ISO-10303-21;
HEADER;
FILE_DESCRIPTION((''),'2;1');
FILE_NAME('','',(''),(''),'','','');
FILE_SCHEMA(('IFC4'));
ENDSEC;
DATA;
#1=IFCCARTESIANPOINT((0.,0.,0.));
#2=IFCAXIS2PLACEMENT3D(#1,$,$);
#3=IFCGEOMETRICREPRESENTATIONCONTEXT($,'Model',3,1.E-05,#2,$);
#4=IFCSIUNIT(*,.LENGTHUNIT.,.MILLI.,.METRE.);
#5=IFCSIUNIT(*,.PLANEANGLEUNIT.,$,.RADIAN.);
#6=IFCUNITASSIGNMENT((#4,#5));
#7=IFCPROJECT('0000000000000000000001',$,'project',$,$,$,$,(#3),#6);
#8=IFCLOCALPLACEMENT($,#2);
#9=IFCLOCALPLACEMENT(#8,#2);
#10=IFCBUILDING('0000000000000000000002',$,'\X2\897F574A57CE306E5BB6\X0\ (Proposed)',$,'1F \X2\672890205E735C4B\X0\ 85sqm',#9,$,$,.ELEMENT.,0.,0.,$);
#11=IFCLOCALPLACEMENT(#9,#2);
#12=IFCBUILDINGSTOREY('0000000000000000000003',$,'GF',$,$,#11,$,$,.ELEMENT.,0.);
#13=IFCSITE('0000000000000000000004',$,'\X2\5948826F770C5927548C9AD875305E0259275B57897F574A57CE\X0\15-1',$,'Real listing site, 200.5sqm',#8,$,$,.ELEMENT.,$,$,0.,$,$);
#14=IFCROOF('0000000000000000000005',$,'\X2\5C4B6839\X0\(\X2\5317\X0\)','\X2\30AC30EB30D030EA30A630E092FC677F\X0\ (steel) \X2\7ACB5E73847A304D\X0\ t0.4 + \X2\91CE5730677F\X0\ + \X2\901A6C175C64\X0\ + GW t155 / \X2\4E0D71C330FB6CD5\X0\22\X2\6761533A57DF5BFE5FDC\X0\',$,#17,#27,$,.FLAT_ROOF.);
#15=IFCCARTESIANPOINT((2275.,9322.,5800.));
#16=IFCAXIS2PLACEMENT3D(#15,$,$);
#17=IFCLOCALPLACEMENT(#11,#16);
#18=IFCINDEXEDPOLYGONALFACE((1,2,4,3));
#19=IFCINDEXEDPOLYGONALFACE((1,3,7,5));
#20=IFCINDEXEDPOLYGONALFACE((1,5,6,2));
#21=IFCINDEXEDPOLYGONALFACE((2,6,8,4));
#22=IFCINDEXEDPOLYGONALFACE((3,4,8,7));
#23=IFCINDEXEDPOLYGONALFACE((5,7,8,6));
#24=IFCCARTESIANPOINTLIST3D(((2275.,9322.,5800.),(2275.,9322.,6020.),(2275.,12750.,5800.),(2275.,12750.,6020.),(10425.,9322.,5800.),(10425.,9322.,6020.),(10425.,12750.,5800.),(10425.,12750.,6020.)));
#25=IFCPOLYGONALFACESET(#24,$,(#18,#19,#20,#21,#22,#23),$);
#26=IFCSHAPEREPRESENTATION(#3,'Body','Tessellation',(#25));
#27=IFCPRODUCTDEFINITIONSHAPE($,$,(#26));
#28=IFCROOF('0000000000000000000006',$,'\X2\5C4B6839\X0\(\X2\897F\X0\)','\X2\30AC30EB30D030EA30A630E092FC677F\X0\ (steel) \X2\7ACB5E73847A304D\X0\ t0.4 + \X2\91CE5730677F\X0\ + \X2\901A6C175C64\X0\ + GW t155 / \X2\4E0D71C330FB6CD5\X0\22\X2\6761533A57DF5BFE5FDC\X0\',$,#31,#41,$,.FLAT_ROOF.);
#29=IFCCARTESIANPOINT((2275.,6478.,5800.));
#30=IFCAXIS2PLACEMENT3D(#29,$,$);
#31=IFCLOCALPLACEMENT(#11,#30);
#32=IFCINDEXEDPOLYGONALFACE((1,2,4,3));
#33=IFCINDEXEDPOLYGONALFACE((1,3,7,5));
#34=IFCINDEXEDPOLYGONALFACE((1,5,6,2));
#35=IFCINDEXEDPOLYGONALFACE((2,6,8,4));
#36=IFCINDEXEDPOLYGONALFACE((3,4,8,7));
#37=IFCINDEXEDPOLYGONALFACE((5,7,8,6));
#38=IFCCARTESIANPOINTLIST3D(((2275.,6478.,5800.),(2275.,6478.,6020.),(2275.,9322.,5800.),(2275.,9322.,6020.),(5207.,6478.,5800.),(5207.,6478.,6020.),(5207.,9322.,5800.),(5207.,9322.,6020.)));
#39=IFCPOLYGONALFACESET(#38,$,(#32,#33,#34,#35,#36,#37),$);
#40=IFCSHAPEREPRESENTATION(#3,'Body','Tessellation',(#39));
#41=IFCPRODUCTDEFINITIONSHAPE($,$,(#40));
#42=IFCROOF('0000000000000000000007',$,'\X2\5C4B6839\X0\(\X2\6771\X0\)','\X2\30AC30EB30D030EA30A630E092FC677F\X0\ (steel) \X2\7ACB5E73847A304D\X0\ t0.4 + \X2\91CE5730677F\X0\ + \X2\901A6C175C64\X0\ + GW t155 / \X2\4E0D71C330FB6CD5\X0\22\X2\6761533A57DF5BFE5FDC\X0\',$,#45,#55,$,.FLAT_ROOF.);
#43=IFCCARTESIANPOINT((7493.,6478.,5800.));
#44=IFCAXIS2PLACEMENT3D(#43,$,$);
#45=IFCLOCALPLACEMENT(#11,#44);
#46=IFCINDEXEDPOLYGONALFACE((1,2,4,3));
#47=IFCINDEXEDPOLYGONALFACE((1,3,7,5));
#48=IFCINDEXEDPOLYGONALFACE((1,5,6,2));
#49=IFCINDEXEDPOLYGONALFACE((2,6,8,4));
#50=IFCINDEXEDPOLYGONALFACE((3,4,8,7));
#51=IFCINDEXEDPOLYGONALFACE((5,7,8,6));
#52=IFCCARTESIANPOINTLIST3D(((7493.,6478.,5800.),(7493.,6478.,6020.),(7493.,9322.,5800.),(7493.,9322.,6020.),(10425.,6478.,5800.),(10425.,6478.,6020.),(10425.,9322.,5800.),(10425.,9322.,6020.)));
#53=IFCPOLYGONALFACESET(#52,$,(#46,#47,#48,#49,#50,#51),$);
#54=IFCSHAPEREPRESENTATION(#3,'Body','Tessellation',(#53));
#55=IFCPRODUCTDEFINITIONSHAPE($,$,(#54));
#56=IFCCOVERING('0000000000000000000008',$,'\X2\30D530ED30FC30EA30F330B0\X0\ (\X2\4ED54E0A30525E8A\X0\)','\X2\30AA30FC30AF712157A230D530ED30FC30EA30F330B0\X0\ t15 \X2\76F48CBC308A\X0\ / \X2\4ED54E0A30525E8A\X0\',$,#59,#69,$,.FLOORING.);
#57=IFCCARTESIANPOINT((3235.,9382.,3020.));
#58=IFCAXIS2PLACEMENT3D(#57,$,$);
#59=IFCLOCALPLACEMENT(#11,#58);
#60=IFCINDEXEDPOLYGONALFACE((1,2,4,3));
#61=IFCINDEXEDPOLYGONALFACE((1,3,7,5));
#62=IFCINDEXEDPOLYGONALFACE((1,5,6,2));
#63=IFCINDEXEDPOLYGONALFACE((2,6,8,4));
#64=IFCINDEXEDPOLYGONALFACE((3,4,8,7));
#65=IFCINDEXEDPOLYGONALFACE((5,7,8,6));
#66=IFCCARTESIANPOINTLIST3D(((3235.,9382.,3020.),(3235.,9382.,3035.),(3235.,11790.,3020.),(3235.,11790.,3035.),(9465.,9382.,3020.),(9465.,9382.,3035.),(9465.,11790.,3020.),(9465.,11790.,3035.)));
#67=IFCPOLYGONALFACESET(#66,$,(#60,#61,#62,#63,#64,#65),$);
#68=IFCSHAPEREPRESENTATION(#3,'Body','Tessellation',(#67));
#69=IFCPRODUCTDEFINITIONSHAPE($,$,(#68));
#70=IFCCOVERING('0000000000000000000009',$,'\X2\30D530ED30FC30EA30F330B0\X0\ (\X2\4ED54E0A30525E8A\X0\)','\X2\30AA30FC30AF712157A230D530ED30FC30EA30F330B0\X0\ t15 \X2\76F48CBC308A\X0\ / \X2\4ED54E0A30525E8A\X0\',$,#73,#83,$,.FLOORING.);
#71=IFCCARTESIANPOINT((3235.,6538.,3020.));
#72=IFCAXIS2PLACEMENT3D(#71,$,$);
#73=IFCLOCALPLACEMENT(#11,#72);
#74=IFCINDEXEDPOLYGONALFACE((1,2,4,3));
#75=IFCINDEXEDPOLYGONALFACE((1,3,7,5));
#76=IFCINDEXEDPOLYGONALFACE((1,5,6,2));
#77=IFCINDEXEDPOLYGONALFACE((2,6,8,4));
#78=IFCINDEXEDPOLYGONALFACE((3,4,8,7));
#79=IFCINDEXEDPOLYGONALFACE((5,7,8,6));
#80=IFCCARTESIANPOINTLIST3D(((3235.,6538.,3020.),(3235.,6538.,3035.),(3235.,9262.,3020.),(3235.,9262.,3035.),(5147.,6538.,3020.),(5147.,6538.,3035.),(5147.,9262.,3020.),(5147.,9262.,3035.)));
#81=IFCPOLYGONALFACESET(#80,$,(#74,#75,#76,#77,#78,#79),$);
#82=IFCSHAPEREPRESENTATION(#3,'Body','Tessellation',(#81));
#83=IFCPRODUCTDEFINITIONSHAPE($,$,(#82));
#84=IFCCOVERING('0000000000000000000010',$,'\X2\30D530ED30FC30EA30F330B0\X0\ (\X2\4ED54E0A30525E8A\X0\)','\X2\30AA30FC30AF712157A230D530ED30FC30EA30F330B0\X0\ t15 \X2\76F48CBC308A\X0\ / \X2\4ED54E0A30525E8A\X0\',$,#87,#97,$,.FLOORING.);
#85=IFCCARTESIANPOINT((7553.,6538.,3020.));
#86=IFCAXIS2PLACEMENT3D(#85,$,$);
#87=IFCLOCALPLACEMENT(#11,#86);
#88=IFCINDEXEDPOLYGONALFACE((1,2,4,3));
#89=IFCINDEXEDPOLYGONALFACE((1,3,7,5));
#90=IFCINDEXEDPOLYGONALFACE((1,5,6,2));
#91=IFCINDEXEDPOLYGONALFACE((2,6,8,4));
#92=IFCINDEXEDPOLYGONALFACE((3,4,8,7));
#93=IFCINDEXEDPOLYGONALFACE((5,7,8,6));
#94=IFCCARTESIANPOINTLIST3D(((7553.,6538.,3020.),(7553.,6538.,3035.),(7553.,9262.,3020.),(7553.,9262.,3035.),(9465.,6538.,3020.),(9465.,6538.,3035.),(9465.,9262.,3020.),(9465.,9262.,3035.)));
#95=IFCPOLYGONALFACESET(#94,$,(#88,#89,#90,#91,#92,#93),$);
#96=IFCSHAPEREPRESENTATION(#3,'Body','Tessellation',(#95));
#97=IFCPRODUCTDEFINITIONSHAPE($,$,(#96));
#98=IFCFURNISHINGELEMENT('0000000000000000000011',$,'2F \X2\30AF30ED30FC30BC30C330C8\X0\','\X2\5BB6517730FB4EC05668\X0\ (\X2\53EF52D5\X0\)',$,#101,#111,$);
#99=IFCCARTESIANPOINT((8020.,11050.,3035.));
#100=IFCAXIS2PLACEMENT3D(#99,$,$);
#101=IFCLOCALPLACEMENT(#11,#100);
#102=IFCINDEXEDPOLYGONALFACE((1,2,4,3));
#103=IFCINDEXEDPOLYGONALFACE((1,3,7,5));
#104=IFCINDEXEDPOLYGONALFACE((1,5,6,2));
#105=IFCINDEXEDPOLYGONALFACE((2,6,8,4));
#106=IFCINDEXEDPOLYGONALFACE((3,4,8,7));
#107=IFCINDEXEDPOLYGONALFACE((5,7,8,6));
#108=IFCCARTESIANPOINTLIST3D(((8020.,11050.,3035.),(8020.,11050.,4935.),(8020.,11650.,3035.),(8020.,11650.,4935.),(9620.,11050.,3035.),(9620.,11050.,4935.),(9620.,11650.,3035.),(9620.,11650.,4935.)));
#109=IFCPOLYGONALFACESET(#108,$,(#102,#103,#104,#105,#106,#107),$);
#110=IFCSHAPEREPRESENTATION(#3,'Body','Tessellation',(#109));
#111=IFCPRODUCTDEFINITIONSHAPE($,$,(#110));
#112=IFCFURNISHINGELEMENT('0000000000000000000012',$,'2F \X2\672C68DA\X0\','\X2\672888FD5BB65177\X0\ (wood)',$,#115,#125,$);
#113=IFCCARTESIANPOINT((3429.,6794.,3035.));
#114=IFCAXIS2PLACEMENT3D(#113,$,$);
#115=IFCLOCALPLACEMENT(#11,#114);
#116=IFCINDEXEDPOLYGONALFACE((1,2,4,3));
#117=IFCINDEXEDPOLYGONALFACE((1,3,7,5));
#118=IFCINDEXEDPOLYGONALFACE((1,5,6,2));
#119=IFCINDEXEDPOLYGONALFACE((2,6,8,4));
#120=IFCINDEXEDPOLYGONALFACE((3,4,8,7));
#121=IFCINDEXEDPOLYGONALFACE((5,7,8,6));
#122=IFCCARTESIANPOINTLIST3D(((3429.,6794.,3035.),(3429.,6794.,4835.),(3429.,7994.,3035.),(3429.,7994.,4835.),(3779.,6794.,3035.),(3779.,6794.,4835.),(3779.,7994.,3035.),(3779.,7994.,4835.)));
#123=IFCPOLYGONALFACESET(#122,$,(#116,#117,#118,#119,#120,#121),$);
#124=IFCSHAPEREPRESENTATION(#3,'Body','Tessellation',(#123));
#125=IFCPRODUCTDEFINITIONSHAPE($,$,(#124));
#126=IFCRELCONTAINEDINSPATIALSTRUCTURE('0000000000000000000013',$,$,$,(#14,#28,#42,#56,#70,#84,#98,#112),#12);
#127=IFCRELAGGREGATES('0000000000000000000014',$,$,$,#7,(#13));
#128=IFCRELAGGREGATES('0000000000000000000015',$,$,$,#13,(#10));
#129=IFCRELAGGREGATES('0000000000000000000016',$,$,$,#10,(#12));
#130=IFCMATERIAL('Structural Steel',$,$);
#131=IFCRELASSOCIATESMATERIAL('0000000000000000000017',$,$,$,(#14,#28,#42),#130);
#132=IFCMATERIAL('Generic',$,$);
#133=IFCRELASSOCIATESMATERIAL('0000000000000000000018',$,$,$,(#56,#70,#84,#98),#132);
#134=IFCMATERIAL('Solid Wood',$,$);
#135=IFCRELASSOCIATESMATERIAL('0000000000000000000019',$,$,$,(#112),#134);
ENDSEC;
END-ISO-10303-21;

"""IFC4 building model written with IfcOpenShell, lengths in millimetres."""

from ifc_helpers import new_model, si_unit, frame, frame_2d, origin, place, context, project, spatial, rectangle, extrude, material, element, save


model = new_model("IFC4")

# Units and contexts
model_context = context("Model", 3, precision=1e-05, world=origin())
ifc_project = project(units=[si_unit("LENGTHUNIT", "METRE", prefix="MILLI"), si_unit("PLANEANGLEUNIT", "RADIAN")], contexts=[model_context])

# Site, building, storey
site_placement = place(None, origin())
site = spatial("IfcSite", under=ifc_project, at=site_placement, Name="奈良県大和高田市大字西坊城15-1", ObjectType="Real listing site, 200.5sqm", CompositionType="ELEMENT", RefElevation=0.0)
building_placement = place(site_placement, origin())
building = spatial("IfcBuilding", under=site, at=building_placement, Name="西坊城の家 (Proposed)", ObjectType="1F 木造平屋 85sqm", CompositionType="ELEMENT", ElevationOfRefHeight=0.0, ElevationOfTerrain=0.0)
storey_placement = place(building_placement, origin())
storey = spatial("IfcBuildingStorey", under=building, at=storey_placement, Name="GF", CompositionType="ELEMENT", Elevation=0.0)

# Shared definitions
ifc_material_1 = material(Name="Solid Wood")

# Shared definitions
ifc_material_2 = material(Name="Generic")

# Roofs
ifc_material_3 = material(Name="Structural Steel")
for number, where, name in (
    (1, (2275.0, 9322.0, 5800.0), "屋根(北)"),
):
    element("IfcRoof", number, at=place(storey_placement, frame(where)), inside=storey, material=ifc_material_3, Name=name, Description="ガルバリウム鋼板 (steel) 立平葺き t0.4 + 野地板 + 通気層 + GW t155 / 不燃・法22条区域対応", PredefinedType="FLAT_ROOF", context=model_context, shape_type="SweptSolid", body=[
        extrude(rectangle(XDim=8150.0, YDim=3428.0, at=frame_2d((4075.0, 1714.0))), frame((2275.0, 9322.0, 5800.0)), (0.0, 0.0, 1.0), 220.0),
    ])
roof_1_placement = place(storey_placement, frame((2275.0, 6478.0, 5800.0)))
element("IfcRoof", 2, at=roof_1_placement, inside=storey, material=ifc_material_3, Name="屋根(西)", Description="ガルバリウム鋼板 (steel) 立平葺き t0.4 + 野地板 + 通気層 + GW t155 / 不燃・法22条区域対応", PredefinedType="FLAT_ROOF", context=model_context, shape_type="SweptSolid", body=[
    extrude(rectangle(XDim=2932.0, YDim=2844.0, at=frame_2d((1466.0, 1422.0))), frame((2275.0, 6478.0, 5800.0)), (0.0, 0.0, 1.0), 220.0),
])
roof_2_placement = place(storey_placement, frame((7493.0, 6478.0, 5800.0)))
element("IfcRoof", 3, at=roof_2_placement, inside=storey, material=ifc_material_3, Name="屋根(東)", Description="ガルバリウム鋼板 (steel) 立平葺き t0.4 + 野地板 + 通気層 + GW t155 / 不燃・法22条区域対応", PredefinedType="FLAT_ROOF", context=model_context, shape_type="SweptSolid", body=[
    extrude(rectangle(XDim=2932.0, YDim=2844.0, at=frame_2d((1466.0, 1422.0))), frame((7493.0, 6478.0, 5800.0)), (0.0, 0.0, 1.0), 220.0),
])

# Coverings
covering_1_placement = place(storey_placement, frame((3235.0, 9382.0, 3020.0)))
element("IfcCovering", 4, at=covering_1_placement, inside=storey, material=ifc_material_2, Name="フローリング (仕上げ床)", Description="オーク無垢フローリング t15 直貼り / 仕上げ床", PredefinedType="FLOORING", context=model_context, shape_type="SweptSolid", body=[
    extrude(rectangle(XDim=6230.0, YDim=2408.0, at=frame_2d((3115.0, 1204.0))), frame((3235.0, 9382.0, 3020.0)), (0.0, 0.0, 1.0), 15.0),
])
covering_2_placement = place(storey_placement, frame((3235.0, 6538.0, 3020.0)))
element("IfcCovering", 5, at=covering_2_placement, inside=storey, material=ifc_material_2, Name="フローリング (仕上げ床)", Description="オーク無垢フローリング t15 直貼り / 仕上げ床", PredefinedType="FLOORING", context=model_context, shape_type="SweptSolid", body=[
    extrude(rectangle(XDim=1912.0, YDim=2724.0, at=frame_2d((956.0, 1362.0))), frame((3235.0, 6538.0, 3020.0)), (0.0, 0.0, 1.0), 15.0),
])
covering_3_placement = place(storey_placement, frame((7553.0, 6538.0, 3020.0)))
element("IfcCovering", 6, at=covering_3_placement, inside=storey, material=ifc_material_2, Name="フローリング (仕上げ床)", Description="オーク無垢フローリング t15 直貼り / 仕上げ床", PredefinedType="FLOORING", context=model_context, shape_type="SweptSolid", body=[
    extrude(rectangle(XDim=1912.0, YDim=2724.0, at=frame_2d((956.0, 1362.0))), frame((7553.0, 6538.0, 3020.0)), (0.0, 0.0, 1.0), 15.0),
])

# Furnishing elements
furnishing_1_placement = place(storey_placement, frame((8020.0, 11050.0, 3035.0)))
element("IfcFurnishingElement", 7, at=furnishing_1_placement, inside=storey, material=ifc_material_2, Name="2F クローゼット", Description="家具・什器 (可動)", context=model_context, shape_type="SweptSolid", body=[
    extrude(rectangle(XDim=1600.0, YDim=600.0, at=frame_2d((800.0, 300.0))), frame((8020.0, 11050.0, 3035.0)), (0.0, 0.0, 1.0), 1900.0),
])
furnishing_2_placement = place(storey_placement, frame((3429.0, 6794.0, 3035.0)))
element("IfcFurnishingElement", 8, at=furnishing_2_placement, inside=storey, material=ifc_material_1, Name="2F 本棚", Description="木製家具 (wood)", context=model_context, shape_type="SweptSolid", body=[
    extrude(rectangle(XDim=350.0, YDim=1200.0, at=frame_2d((175.0, 600.0))), frame((3429.0, 6794.0, 3035.0)), (0.0, 0.0, 1.0), 1800.0),
])

save(model, "model.ifc")
